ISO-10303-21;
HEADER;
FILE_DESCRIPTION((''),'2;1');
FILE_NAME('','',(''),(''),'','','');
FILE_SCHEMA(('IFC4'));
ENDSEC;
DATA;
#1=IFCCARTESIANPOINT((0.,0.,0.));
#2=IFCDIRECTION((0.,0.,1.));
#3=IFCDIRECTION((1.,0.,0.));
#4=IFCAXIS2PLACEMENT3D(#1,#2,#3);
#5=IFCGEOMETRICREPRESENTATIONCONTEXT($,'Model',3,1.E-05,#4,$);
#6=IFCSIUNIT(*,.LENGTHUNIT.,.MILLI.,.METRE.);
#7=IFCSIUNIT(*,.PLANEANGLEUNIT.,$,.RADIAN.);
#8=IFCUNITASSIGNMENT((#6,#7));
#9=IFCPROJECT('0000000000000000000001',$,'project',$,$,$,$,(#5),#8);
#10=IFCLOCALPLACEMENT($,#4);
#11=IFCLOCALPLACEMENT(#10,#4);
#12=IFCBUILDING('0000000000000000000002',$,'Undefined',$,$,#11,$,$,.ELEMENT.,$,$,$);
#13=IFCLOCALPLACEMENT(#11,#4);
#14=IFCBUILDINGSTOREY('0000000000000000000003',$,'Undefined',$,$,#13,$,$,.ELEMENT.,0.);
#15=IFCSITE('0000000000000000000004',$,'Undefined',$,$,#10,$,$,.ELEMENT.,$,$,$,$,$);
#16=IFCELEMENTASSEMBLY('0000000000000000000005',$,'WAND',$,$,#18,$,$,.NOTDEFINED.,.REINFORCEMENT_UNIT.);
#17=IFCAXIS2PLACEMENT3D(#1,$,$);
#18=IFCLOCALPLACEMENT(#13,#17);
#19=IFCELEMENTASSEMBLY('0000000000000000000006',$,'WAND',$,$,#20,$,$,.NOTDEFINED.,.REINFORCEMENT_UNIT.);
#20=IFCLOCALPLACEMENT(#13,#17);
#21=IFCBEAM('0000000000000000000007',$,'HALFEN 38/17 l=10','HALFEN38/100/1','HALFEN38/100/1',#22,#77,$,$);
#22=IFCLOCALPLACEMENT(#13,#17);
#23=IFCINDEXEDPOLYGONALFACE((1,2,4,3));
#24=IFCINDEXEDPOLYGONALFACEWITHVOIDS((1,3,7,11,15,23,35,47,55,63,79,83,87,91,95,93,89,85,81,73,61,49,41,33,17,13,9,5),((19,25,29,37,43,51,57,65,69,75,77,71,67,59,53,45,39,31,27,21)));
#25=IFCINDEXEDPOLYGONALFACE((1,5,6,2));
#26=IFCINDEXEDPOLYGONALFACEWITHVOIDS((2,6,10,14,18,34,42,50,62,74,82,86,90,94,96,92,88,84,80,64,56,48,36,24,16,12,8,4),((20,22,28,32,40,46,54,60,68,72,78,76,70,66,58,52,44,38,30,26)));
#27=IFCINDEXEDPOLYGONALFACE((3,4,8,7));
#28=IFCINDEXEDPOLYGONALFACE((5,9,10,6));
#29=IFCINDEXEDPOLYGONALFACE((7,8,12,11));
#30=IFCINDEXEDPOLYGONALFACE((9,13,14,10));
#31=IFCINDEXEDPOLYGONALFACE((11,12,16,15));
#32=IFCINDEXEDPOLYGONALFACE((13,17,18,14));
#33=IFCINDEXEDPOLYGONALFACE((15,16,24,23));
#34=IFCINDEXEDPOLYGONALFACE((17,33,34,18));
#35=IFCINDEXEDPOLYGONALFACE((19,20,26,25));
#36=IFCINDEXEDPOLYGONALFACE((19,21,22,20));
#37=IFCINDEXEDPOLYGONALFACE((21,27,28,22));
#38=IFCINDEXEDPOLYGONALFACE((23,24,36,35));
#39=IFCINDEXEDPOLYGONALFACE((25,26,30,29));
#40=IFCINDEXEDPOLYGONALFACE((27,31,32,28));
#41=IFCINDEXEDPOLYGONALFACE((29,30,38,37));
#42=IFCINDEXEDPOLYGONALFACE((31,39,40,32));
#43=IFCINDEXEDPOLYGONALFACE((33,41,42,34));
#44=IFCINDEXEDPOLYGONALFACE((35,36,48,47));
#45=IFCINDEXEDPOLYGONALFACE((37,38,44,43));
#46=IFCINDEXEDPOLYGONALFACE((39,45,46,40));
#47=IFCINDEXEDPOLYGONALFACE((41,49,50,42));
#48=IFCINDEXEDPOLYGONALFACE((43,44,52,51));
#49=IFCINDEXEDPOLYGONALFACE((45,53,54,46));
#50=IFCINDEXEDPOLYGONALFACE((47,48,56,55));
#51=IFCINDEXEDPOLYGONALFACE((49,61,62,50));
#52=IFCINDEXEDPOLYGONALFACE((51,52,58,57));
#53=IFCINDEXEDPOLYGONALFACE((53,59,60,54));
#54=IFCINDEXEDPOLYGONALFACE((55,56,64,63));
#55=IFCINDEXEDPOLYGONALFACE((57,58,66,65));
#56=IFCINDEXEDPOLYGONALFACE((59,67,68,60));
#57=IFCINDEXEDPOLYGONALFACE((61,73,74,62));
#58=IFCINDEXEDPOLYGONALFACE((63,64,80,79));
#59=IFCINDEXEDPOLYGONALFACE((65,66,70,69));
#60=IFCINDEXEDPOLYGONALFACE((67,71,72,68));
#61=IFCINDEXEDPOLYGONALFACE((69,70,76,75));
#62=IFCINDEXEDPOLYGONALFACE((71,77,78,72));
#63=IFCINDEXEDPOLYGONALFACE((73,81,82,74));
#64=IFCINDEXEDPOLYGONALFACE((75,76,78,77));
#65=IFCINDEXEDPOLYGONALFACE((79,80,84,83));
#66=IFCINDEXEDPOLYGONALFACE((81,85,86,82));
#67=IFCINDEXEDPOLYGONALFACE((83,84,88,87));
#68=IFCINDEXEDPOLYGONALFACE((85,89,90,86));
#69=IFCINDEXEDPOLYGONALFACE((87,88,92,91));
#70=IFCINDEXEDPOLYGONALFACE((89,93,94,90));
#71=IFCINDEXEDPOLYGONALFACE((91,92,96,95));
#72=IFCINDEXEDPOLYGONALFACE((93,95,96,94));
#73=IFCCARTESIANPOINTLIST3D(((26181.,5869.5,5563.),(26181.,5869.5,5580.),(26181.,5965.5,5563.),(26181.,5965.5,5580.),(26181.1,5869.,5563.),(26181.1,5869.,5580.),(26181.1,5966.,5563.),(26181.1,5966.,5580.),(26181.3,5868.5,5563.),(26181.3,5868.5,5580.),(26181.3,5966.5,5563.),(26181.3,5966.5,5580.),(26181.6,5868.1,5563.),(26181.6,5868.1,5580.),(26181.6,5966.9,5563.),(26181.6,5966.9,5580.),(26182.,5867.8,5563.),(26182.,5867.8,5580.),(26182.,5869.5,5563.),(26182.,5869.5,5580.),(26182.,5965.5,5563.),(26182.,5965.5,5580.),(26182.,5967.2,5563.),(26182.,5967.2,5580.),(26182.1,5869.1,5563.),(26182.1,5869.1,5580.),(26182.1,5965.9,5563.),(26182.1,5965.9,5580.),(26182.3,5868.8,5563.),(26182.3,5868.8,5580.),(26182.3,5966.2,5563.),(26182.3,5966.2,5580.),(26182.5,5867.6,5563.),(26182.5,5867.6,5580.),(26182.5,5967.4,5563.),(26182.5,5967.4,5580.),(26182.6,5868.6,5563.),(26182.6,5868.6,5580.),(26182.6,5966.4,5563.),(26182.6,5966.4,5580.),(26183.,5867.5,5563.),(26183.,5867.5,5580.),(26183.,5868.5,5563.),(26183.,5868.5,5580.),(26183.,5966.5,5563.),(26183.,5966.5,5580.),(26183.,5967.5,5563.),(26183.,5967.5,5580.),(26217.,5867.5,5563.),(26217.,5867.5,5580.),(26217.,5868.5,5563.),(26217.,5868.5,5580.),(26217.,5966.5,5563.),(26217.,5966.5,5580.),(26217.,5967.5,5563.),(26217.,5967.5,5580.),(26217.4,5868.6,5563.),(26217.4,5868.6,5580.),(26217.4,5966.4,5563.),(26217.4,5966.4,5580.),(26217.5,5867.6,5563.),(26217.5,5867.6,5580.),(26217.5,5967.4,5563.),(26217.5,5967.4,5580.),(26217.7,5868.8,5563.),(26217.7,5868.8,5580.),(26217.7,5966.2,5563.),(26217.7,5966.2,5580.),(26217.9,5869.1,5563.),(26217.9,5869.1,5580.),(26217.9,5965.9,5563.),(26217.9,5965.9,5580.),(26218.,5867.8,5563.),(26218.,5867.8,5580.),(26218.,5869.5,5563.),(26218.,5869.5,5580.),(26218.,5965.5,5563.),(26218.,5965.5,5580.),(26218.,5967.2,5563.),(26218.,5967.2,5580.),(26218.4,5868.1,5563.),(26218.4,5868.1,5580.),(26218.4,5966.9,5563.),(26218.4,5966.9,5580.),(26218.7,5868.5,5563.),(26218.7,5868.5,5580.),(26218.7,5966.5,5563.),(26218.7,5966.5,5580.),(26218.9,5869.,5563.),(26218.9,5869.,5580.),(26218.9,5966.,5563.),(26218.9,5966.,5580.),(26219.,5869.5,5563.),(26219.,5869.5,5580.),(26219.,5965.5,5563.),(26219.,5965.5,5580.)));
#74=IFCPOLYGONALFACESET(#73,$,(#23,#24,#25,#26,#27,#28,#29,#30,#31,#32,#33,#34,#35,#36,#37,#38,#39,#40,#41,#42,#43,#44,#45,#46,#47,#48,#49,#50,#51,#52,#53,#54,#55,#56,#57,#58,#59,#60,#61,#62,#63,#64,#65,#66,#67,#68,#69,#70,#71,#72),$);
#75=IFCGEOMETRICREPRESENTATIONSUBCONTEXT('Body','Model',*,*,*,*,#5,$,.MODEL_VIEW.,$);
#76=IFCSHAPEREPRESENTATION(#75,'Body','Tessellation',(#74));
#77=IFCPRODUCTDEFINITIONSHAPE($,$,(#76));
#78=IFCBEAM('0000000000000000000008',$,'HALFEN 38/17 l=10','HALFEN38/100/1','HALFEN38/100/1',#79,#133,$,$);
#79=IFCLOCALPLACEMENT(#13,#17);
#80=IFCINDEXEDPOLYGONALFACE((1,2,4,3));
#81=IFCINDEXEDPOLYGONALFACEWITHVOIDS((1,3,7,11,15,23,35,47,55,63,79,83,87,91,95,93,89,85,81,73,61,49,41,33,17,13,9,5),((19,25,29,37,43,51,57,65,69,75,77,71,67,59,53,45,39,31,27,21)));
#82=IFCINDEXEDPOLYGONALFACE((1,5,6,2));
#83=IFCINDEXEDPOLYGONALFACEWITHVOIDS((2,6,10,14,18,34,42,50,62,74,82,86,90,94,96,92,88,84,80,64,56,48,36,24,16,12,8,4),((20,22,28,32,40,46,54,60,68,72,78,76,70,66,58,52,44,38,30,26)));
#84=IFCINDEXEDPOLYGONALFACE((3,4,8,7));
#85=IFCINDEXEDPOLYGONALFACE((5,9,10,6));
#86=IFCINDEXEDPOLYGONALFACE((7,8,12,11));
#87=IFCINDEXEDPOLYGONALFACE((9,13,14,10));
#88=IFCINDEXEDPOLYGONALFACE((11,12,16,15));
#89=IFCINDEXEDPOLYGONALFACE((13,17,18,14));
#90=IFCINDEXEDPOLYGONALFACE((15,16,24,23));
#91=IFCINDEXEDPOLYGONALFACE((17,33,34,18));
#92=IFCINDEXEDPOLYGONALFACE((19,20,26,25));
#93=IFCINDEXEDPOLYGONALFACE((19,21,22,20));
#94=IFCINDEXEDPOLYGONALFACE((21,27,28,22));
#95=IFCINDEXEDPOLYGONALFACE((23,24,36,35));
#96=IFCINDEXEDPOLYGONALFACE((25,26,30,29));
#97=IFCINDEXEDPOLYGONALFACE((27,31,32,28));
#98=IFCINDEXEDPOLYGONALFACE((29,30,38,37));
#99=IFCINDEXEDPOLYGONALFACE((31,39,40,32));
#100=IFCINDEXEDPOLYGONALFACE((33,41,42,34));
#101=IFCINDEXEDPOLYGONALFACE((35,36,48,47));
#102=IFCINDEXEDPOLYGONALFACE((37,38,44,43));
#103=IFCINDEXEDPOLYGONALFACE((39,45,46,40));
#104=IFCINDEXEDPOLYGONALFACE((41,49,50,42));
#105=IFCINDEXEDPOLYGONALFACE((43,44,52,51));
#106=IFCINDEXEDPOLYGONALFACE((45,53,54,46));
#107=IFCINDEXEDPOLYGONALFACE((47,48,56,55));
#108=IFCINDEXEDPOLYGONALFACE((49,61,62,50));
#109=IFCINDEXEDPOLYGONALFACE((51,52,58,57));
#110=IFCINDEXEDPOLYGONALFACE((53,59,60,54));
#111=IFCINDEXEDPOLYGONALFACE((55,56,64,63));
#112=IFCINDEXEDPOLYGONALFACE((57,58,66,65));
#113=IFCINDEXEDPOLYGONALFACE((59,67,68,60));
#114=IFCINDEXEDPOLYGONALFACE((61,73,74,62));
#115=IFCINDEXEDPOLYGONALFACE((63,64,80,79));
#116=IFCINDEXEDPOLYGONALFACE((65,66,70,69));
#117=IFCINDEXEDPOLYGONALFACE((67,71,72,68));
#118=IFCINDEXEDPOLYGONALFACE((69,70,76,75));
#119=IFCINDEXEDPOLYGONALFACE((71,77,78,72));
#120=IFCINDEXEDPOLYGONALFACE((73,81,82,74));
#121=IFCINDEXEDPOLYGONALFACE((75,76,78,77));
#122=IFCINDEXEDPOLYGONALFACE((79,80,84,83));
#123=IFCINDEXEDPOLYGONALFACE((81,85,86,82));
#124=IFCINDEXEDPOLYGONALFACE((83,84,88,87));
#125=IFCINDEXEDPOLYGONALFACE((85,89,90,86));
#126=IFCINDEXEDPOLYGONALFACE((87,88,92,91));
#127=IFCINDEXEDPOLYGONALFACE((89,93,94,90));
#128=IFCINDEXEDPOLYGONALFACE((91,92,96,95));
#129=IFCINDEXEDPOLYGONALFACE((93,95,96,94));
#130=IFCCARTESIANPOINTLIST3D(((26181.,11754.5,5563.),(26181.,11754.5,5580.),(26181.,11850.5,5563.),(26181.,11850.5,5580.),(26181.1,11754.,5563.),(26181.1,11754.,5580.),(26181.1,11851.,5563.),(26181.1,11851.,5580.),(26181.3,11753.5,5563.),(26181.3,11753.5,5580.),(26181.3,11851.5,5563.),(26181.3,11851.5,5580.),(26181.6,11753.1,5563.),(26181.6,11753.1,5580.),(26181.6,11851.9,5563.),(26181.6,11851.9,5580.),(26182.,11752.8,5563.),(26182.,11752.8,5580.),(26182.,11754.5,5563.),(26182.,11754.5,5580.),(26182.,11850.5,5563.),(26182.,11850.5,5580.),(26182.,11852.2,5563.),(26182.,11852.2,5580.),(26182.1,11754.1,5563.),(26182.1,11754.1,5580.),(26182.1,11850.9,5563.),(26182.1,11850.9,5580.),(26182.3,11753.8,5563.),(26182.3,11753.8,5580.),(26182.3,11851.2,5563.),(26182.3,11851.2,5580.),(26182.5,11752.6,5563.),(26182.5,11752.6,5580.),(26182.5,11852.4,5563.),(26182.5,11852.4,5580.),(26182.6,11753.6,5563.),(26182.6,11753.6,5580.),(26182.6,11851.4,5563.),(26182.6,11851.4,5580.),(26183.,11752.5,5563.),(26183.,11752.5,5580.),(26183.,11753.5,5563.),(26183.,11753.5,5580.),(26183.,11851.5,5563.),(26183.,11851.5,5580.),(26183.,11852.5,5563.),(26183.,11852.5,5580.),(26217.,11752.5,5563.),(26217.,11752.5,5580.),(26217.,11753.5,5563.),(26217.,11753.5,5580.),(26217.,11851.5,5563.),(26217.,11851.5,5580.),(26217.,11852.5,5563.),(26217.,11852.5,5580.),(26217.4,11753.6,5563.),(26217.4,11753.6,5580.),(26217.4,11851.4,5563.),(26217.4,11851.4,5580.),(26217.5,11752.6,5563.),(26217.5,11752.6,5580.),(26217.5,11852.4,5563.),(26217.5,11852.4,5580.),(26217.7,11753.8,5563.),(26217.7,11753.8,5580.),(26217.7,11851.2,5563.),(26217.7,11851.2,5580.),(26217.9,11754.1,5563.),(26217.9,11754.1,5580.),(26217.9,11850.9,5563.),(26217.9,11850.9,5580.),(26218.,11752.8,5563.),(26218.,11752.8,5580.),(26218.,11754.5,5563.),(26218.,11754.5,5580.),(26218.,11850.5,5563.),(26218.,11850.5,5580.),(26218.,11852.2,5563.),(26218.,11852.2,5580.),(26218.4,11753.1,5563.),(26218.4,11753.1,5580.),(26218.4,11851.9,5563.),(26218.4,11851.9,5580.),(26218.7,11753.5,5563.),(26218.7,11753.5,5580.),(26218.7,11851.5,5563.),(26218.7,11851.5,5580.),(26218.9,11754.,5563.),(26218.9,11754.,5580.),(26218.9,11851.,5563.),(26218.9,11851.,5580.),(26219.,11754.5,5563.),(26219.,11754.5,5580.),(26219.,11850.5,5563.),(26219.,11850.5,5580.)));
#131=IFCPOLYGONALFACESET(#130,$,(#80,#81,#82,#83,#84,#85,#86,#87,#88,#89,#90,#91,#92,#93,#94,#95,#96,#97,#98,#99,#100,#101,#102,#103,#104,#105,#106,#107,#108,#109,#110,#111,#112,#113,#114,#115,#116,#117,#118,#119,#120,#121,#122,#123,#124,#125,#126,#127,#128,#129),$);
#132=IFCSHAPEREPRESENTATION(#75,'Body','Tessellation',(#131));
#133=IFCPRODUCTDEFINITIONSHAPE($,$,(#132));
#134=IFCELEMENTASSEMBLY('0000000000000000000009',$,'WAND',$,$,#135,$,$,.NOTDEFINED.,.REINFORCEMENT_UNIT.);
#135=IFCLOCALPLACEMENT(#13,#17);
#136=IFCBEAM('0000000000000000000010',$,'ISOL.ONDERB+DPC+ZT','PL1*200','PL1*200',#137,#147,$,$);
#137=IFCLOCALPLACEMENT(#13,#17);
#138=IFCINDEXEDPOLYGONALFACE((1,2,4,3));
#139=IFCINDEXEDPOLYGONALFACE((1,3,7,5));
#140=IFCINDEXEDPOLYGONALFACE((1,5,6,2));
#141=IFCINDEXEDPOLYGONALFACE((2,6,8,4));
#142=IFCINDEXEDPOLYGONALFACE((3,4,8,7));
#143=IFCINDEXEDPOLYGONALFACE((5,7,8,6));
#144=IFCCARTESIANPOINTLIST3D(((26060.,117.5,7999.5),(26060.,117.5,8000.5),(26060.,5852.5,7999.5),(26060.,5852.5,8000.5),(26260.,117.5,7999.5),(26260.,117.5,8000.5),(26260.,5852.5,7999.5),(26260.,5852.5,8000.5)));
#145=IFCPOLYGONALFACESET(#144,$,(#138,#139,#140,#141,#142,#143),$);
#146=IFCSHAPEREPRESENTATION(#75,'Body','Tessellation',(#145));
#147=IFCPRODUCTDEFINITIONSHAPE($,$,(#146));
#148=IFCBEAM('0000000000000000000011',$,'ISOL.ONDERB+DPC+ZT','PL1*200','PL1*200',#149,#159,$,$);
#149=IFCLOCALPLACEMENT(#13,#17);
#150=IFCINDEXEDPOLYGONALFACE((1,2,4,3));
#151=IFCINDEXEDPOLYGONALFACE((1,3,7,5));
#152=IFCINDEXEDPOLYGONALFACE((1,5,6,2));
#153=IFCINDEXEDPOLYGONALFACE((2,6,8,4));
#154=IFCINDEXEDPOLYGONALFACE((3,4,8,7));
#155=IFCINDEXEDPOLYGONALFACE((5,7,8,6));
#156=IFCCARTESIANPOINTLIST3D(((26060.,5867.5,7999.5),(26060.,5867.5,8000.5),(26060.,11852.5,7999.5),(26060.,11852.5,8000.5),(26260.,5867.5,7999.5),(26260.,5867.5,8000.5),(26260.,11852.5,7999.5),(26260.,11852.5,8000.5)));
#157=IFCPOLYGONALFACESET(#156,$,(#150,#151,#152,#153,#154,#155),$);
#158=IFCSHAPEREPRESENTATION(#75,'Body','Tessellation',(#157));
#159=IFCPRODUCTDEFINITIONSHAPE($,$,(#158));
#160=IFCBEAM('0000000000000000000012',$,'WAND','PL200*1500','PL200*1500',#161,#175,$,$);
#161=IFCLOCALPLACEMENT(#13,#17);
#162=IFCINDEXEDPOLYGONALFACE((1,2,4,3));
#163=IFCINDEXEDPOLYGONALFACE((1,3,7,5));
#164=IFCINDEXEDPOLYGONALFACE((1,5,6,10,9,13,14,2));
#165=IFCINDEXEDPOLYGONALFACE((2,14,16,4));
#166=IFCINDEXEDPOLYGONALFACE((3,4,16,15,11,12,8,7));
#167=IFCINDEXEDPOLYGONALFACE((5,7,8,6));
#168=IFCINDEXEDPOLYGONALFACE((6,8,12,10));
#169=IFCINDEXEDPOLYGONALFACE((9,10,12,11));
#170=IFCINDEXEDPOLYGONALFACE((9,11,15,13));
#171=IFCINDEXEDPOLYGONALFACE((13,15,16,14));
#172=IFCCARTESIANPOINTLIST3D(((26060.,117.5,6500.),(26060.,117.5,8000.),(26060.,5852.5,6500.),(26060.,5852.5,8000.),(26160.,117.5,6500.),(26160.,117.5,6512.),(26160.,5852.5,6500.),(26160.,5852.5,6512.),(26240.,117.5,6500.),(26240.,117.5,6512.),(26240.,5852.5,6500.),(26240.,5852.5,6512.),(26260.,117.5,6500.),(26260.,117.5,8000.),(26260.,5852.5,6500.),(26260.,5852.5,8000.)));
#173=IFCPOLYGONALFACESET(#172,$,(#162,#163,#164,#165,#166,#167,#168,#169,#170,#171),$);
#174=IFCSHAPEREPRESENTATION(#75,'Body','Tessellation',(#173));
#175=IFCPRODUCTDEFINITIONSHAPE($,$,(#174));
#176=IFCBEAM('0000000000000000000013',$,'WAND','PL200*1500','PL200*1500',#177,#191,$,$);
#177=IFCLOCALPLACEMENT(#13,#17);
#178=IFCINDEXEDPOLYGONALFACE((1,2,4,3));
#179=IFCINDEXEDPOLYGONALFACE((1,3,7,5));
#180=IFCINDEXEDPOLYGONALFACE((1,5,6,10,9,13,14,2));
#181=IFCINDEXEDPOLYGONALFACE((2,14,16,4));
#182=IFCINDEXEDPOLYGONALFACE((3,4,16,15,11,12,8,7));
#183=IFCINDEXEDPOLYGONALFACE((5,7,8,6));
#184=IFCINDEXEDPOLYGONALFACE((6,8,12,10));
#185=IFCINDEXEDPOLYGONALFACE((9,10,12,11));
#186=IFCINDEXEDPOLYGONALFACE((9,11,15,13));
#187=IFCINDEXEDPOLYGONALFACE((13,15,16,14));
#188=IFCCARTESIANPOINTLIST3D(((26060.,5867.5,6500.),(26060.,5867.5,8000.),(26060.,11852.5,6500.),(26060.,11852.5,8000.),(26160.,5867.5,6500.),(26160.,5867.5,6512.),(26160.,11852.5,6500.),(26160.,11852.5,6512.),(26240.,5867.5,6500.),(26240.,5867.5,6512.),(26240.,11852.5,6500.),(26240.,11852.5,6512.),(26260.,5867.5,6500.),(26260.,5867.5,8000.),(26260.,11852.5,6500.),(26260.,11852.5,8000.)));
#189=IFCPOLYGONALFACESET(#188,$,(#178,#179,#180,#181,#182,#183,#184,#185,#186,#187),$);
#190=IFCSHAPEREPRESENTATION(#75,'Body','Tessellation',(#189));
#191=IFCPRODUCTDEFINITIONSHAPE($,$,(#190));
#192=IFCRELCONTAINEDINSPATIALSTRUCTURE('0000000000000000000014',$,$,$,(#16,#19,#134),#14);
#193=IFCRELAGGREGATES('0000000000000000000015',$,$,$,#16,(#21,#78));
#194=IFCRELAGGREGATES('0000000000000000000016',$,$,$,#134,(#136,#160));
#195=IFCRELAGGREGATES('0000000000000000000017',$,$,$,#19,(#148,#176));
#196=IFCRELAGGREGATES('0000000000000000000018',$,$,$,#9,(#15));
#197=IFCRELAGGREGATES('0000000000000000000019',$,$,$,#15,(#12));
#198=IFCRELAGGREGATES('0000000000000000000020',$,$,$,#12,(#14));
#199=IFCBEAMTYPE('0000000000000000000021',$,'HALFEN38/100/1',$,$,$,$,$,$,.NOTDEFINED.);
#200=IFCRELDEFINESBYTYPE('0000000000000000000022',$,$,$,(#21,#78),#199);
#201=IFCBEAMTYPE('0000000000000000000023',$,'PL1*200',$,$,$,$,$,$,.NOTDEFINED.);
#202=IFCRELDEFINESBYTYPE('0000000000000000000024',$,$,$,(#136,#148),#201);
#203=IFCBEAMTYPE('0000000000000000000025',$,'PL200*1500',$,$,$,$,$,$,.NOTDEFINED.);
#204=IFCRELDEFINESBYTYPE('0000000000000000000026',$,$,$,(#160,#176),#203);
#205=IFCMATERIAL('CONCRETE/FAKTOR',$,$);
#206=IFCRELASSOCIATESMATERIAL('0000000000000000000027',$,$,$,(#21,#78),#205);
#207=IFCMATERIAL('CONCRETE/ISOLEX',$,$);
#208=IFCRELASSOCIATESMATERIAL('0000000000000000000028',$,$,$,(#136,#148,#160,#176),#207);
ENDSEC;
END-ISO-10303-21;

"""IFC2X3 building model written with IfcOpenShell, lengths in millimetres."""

from ifc_helpers import new_model, si_unit, frame, frame_2d, origin_with_axes, place, context, subcontext, project, spatial, rectangle, hollow_rectangle, extrude, boolean, material, type_object, element, aggregate, save


model = new_model("IFC2X3")

# Units and contexts
model_context = context("Model", 3, precision=1e-05, world=origin_with_axes())
body_context = subcontext(model_context, "Body", "Model", "MODEL_VIEW")
ifc_project = project(units=[si_unit("LENGTHUNIT", "METRE", prefix="MILLI"), si_unit("PLANEANGLEUNIT", "RADIAN")], contexts=[model_context])

# Site, building, storey
site_placement = place(None, origin_with_axes())
site = spatial("IfcSite", under=ifc_project, at=site_placement, Name="Undefined", CompositionType="ELEMENT")
building_placement = place(site_placement, origin_with_axes())
building = spatial("IfcBuilding", under=site, at=building_placement, Name="Undefined", CompositionType="ELEMENT")
storey_placement = place(building_placement, origin_with_axes())
storey = spatial("IfcBuildingStorey", under=building, at=storey_placement, Name="Undefined", CompositionType="ELEMENT", Elevation=0.0)

# Element assembly
assembly_1_placement = place(storey_placement, origin_with_axes())
assembly_1 = element("IfcElementAssembly", 1, at=assembly_1_placement, inside=storey, Name="WAND", AssemblyPlace="NOTDEFINED", PredefinedType="REINFORCEMENT_UNIT")
ifc_material_1 = material(Name="CONCRETE/FAKTOR")

# Element assembly
assembly_2_placement = place(storey_placement, origin_with_axes())
assembly_2 = element("IfcElementAssembly", 2, at=assembly_2_placement, inside=storey, Name="WAND", AssemblyPlace="NOTDEFINED", PredefinedType="REINFORCEMENT_UNIT")

# Beams
beam_type_1 = type_object("IfcBeamType", Name="HALFEN38/100/1", PredefinedType="NOTDEFINED")
beam_1_placement = place(assembly_1_placement, frame((26200.0, 5917.5, 5580.0), z_axis=(-1.0, 0.0, 0.0), x_axis=(0.0, 0.0, -1.0)))
beam_1 = element("IfcBeam", 3, at=beam_1_placement, type_object=beam_type_1, material=ifc_material_1, Name="HALFEN 38/17 l=10", Description="HALFEN38/100/1", ObjectType="HALFEN38/100/1", context=body_context, shape_type="SweptSolid", body=[
    extrude(hollow_rectangle(XDim=100.0, YDim=38.0, WallThickness=1.0, InnerFilletRadius=1.0, OuterFilletRadius=2.0, at=frame_2d((0.0, 0.0), x_axis=(1.0, 0.0))), frame((17.0, 0.0, 0.0), z_axis=(-1.0, 0.0, 0.0), x_axis=(0.0, -1.0, 0.0)), (0.0, 0.0, 1.0), 17.0),
])
beam_2_placement = place(assembly_1_placement, frame((26200.0, 11802.5, 5580.0), z_axis=(-1.0, 0.0, 0.0), x_axis=(0.0, 0.0, -1.0)))
beam_2 = element("IfcBeam", 4, at=beam_2_placement, type_object=beam_type_1, material=ifc_material_1, Name="HALFEN 38/17 l=10", Description="HALFEN38/100/1", ObjectType="HALFEN38/100/1", context=body_context, shape_type="SweptSolid", body=[
    extrude(hollow_rectangle(XDim=100.0, YDim=38.0, WallThickness=1.0, InnerFilletRadius=1.0, OuterFilletRadius=2.0, at=frame_2d((0.0, 0.0), x_axis=(1.0, 0.0))), frame((17.0, 0.0, 0.0), z_axis=(-1.0, 0.0, 0.0), x_axis=(0.0, -1.0, 0.0)), (0.0, 0.0, 1.0), 17.0),
])
aggregate(assembly_1, [beam_1, beam_2])

# Element assembly, beam
assembly_3_placement = place(storey_placement, origin_with_axes())
assembly_3 = element("IfcElementAssembly", 5, at=assembly_3_placement, inside=storey, Name="WAND", AssemblyPlace="NOTDEFINED", PredefinedType="REINFORCEMENT_UNIT")
ifc_material_2 = material(Name="CONCRETE/ISOLEX")
beam_type_2 = type_object("IfcBeamType", Name="PL1*200", PredefinedType="NOTDEFINED")
beam_3_placement = place(assembly_3_placement, frame((26160.0, 5852.5, 8000.0), z_axis=(-1.0, 0.0, 0.0), x_axis=(0.0, -1.0, 0.0)))
beam_3 = element("IfcBeam", 6, at=beam_3_placement, type_object=beam_type_2, material=ifc_material_2, Name="ISOL.ONDERB+DPC+ZT", Description="PL1*200", ObjectType="PL1*200", context=body_context, shape_type="SweptSolid", body=[
    extrude(rectangle(XDim=1.0, YDim=200.0, at=frame_2d((0.0, 0.0), x_axis=(1.0, 0.0))), frame((5735.0, 0.0, 0.0), z_axis=(-1.0, 0.0, 0.0), x_axis=(0.0, -1.0, 0.0)), (0.0, 0.0, 1.0), 5735.0),
])

# Beams
beam_4_placement = place(assembly_2_placement, frame((26160.0, 11852.5, 8000.0), z_axis=(-1.0, 0.0, 0.0), x_axis=(0.0, -1.0, 0.0)))
beam_4 = element("IfcBeam", 7, at=beam_4_placement, type_object=beam_type_2, material=ifc_material_2, Name="ISOL.ONDERB+DPC+ZT", Description="PL1*200", ObjectType="PL1*200", context=body_context, shape_type="SweptSolid", body=[
    extrude(rectangle(XDim=1.0, YDim=200.0, at=frame_2d((0.0, 0.0), x_axis=(1.0, 0.0))), frame((5985.0, 0.0, 0.0), z_axis=(-1.0, 0.0, 0.0), x_axis=(0.0, -1.0, 0.0)), (0.0, 0.0, 1.0), 5985.0),
])
beam_type_3 = type_object("IfcBeamType", Name="PL200*1500", PredefinedType="NOTDEFINED")
beam_5_placement = place(assembly_3_placement, frame((26160.0, 5852.5, 7250.0), z_axis=(0.0, 0.0, 1.0), x_axis=(0.0, -1.0, 0.0)))
beam_5 = element("IfcBeam", 8, at=beam_5_placement, type_object=beam_type_3, material=ifc_material_2, Name="WAND", Description="PL200*1500", ObjectType="PL200*1500", context=body_context, shape_type="CSG", body=[
    boolean("DIFFERENCE", extrude(rectangle(XDim=200.0, YDim=1500.0, at=frame_2d((0.0, 0.0), x_axis=(1.0, 0.0))), frame((5735.0, 0.0, 0.0), z_axis=(-1.0, 0.0, 0.0), x_axis=(0.0, -1.0, 0.0)), (0.0, 0.0, 1.0), 5735.0), extrude(rectangle(XDim=12.0, YDim=80.0, at=frame_2d((0.0, 0.0), x_axis=(1.0, 0.0))), frame((5742.5, 40.0, -744.0), z_axis=(-1.0, 0.0, 0.0), x_axis=(0.0, 0.0, -1.0)), (0.0, 0.0, 1.0), 5742.5)),
])
aggregate(assembly_3, [beam_3, beam_5])
beam_6_placement = place(assembly_2_placement, frame((26160.0, 11852.5, 7250.0), z_axis=(0.0, 0.0, 1.0), x_axis=(0.0, -1.0, 0.0)))
beam_6 = element("IfcBeam", 9, at=beam_6_placement, type_object=beam_type_3, material=ifc_material_2, Name="WAND", Description="PL200*1500", ObjectType="PL200*1500", context=body_context, shape_type="CSG", body=[
    boolean("DIFFERENCE", extrude(rectangle(XDim=200.0, YDim=1500.0, at=frame_2d((0.0, 0.0), x_axis=(1.0, 0.0))), frame((5985.0, 0.0, 0.0), z_axis=(-1.0, 0.0, 0.0), x_axis=(0.0, -1.0, 0.0)), (0.0, 0.0, 1.0), 5985.0), extrude(rectangle(XDim=12.0, YDim=80.0, at=frame_2d((0.0, 0.0), x_axis=(1.0, 0.0))), frame((5985.0, 40.0, -744.0), z_axis=(-1.0, 0.0, 0.0), x_axis=(0.0, 0.0, -1.0)), (0.0, 0.0, 1.0), 5985.0)),
])
aggregate(assembly_2, [beam_4, beam_6])

save(model, "model.ifc")
